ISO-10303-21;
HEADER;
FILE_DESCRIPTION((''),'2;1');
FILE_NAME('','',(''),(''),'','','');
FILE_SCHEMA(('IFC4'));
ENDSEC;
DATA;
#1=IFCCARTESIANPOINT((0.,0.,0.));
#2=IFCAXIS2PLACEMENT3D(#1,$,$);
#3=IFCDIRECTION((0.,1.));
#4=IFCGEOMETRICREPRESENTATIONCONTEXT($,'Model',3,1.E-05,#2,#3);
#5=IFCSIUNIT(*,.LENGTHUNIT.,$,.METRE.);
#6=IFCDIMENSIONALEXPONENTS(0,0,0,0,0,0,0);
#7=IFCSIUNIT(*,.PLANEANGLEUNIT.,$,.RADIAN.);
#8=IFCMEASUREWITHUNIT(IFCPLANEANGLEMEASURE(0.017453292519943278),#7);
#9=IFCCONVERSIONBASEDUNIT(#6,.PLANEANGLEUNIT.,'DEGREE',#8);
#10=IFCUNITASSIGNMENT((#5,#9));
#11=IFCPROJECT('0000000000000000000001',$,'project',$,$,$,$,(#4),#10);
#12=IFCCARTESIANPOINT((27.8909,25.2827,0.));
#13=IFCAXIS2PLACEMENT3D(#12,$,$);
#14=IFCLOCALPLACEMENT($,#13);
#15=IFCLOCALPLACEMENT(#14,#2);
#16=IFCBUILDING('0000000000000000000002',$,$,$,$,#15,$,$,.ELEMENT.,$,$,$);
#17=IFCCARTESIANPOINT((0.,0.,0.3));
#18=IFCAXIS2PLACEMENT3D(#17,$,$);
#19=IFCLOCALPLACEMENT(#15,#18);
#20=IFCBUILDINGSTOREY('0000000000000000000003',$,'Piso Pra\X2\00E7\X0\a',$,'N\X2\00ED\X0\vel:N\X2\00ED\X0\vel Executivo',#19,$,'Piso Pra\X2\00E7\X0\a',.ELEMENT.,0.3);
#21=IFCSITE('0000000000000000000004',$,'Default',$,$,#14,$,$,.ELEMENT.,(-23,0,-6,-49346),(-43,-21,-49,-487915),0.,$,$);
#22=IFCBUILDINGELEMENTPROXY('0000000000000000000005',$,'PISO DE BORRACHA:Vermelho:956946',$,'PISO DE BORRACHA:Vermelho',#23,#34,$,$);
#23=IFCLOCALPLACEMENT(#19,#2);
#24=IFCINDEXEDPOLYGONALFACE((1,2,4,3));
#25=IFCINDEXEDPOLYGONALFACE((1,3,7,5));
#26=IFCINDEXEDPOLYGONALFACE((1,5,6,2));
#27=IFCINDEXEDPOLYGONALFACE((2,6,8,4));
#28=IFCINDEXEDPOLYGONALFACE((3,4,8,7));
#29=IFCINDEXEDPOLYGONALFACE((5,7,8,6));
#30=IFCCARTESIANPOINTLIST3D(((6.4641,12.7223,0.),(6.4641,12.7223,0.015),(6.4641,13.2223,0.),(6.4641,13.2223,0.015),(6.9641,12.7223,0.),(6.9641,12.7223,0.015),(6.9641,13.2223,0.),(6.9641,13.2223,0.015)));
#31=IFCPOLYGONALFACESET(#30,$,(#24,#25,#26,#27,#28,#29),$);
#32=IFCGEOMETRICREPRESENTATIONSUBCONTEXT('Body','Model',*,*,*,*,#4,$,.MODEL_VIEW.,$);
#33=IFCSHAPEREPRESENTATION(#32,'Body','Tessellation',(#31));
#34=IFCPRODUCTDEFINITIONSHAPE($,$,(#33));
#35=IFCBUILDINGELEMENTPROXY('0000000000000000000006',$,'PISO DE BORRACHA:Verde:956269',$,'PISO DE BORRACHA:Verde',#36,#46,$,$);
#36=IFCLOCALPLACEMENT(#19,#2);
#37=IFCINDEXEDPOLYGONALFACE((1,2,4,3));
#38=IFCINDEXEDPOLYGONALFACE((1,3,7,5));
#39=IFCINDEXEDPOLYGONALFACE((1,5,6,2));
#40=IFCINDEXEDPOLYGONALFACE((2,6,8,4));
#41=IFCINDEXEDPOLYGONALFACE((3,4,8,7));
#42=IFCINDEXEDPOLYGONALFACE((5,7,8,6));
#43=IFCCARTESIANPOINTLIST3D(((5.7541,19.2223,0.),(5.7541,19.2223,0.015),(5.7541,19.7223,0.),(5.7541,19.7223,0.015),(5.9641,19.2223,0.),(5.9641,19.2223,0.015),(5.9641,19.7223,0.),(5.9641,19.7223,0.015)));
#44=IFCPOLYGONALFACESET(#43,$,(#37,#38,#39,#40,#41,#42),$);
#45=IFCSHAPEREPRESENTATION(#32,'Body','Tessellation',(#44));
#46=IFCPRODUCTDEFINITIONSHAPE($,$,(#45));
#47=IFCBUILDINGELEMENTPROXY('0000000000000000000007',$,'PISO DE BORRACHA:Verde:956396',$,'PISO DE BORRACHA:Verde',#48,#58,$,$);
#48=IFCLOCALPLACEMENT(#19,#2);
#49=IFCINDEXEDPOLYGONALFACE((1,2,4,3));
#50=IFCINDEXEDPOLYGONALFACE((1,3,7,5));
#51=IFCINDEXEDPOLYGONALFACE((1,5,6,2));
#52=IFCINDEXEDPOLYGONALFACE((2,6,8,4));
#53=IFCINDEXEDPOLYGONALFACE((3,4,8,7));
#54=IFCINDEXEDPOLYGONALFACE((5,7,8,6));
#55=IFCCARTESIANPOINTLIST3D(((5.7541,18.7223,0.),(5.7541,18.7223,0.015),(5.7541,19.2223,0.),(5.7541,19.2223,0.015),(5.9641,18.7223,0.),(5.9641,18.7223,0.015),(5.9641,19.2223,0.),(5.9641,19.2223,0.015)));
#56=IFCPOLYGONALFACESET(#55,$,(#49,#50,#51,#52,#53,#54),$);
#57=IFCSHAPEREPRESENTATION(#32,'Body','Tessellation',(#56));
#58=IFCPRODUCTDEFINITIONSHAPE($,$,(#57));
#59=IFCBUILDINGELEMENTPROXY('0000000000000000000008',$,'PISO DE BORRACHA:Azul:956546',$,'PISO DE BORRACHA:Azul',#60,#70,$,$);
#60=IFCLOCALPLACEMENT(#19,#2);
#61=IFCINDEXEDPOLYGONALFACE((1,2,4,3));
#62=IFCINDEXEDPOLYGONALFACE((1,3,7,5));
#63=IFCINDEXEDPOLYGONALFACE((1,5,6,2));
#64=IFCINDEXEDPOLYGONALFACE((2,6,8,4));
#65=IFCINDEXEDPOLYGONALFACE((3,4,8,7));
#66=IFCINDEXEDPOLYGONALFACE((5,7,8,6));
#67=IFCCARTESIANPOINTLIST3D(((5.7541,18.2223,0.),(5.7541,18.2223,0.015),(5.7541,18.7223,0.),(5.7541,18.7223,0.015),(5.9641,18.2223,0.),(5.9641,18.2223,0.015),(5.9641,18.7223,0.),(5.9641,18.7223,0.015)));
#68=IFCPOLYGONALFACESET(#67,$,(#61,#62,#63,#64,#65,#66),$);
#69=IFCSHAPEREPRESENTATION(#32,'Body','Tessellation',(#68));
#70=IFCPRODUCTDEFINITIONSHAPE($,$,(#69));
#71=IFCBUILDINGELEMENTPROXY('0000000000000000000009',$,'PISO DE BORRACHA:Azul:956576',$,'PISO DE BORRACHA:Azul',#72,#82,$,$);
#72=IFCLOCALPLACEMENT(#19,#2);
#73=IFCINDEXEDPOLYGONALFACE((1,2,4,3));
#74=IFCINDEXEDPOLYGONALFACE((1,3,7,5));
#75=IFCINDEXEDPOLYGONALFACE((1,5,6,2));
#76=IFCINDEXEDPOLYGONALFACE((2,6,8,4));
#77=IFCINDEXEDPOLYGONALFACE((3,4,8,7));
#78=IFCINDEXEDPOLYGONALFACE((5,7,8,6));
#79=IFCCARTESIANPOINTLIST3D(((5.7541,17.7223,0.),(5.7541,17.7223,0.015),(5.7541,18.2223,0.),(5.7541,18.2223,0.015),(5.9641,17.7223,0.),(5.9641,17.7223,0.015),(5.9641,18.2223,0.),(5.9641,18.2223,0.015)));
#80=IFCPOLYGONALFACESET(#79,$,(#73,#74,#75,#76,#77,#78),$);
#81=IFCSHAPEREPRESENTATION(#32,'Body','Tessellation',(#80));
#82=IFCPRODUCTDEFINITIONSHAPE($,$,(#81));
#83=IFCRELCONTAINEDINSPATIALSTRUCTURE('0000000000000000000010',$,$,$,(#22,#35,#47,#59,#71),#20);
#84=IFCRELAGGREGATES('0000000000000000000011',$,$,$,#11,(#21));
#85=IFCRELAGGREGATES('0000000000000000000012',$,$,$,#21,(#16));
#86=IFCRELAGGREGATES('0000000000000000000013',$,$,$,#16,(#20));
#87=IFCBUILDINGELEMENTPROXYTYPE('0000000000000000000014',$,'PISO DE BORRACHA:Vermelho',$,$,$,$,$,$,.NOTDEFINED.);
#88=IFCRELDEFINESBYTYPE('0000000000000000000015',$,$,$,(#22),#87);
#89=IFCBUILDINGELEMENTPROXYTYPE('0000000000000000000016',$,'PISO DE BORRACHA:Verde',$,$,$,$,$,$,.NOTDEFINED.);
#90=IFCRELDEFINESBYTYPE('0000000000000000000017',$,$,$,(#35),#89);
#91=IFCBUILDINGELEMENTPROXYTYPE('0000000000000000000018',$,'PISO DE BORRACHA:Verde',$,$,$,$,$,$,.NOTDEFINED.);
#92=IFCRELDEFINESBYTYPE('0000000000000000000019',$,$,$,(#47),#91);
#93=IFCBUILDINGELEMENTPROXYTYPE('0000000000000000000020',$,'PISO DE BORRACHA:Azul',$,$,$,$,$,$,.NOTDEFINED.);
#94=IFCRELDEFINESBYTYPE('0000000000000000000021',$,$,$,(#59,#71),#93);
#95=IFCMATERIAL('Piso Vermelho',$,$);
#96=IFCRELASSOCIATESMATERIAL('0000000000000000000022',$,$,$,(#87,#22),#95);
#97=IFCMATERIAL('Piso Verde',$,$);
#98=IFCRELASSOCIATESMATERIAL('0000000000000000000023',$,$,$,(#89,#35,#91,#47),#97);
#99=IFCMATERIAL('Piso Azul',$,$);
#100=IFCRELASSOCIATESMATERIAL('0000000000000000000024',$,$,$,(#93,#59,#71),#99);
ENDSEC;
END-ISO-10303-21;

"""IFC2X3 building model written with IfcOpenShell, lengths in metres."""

from ifc_helpers import new_model, entity, si_unit, converted_unit, direction, frame, frame_2d, origin, origin_2d_with_axis, place, context, subcontext, project, spatial, rectangle, extrude, source, transform, mapped, material, type_object, type_shapes, element, save


model = new_model("IFC2X3")

# Units and contexts
model_context = context("Model", 3, precision=1e-05, world=origin(), true_north=direction((0.0, 1.0)))
body_context = subcontext(model_context, "Body", "Model", "MODEL_VIEW")
ifc_project = project(units=[si_unit("LENGTHUNIT", "METRE"), converted_unit("PLANEANGLEUNIT", "DEGREE", entity("IfcPlaneAngleMeasure", 0.017453292519943278), si_unit("PLANEANGLEUNIT", "RADIAN"), dimensions=[0, 0, 0, 0, 0, 0, 0])], contexts=[model_context])

# Site, building, storey
site_placement = place(None, frame((27.8909, 25.2827, 0.0)))
site = spatial("IfcSite", under=ifc_project, at=site_placement, Name="Default", CompositionType="ELEMENT", RefLatitude=(-23, 0, -6, -49346), RefLongitude=(-43, -21, -49, -487915), RefElevation=0.0)
building_placement = place(site_placement, origin())
building = spatial("IfcBuilding", under=site, at=building_placement, CompositionType="ELEMENT")
storey_placement = place(building_placement, frame((0.0, 0.0, 0.3)))
storey = spatial("IfcBuildingStorey", under=building, at=storey_placement, Name="Piso Praça", ObjectType="Nível:Nível Executivo", LongName="Piso Praça", CompositionType="ELEMENT", Elevation=0.3)

# Building element proxies
ifc_material_1 = material(Name="Piso Verde")
ifc_material_2 = material(Name="Piso Azul")
ifc_material_3 = material(Name="Piso Vermelho")
building_element_proxy_type_1 = type_object("IfcBuildingElementProxyType", Name="PISO DE BORRACHA:Vermelho", PredefinedType="NOTDEFINED", material=ifc_material_3)
shared_shape_1 = source(origin(), body_context, "Body", "SweptSolid", [
    extrude(rectangle(XDim=0.5, YDim=0.5, at=origin_2d_with_axis()), frame((0.25, 0.25, 0.0), z_axis=(0.0, 0.0, 1.0), x_axis=(-1.0, 0.0, 0.0)), (0.0, 0.0, 1.0), 0.015),
])
type_shapes(building_element_proxy_type_1, [shared_shape_1])
for number, where, name in (
    (1, (6.4641, 12.7223, 0.0), "PISO DE BORRACHA:Vermelho:956946"),
):
    element("IfcBuildingElementProxy", number, at=place(storey_placement, frame(where)), inside=storey, type_object=building_element_proxy_type_1, material=ifc_material_3, Name=name, ObjectType="PISO DE BORRACHA:Vermelho", context=body_context, shape_type="MappedRepresentation", body=[
        mapped(shared_shape_1, transform((0.0, 0.0, 0.0), scale=1.0)),
    ])
building_element_proxy_type_2 = type_object("IfcBuildingElementProxyType", Name="PISO DE BORRACHA:Verde", PredefinedType="NOTDEFINED", material=ifc_material_1)
shared_shape_2 = source(origin(), body_context, "Body", "SweptSolid", [
    extrude(rectangle(XDim=0.21, YDim=0.5, at=frame_2d((0.0, 0.0), x_axis=(1.0, 0.0))), frame((0.105, 0.25, 0.0), z_axis=(0.0, 0.0, 1.0), x_axis=(-1.0, 0.0, 0.0)), (0.0, 0.0, 1.0), 0.015),
])
type_shapes(building_element_proxy_type_2, [shared_shape_2])
proxy_1_placement = place(storey_placement, frame((5.7541, 19.2223, 0.0)))
element("IfcBuildingElementProxy", 2, at=proxy_1_placement, inside=storey, type_object=building_element_proxy_type_2, material=ifc_material_1, Name="PISO DE BORRACHA:Verde:956269", ObjectType="PISO DE BORRACHA:Verde", context=body_context, shape_type="MappedRepresentation", body=[
    mapped(shared_shape_2, transform((0.0, 0.0, 0.0), scale=1.0)),
])
building_element_proxy_type_3 = type_object("IfcBuildingElementProxyType", Name="PISO DE BORRACHA:Verde", PredefinedType="NOTDEFINED", material=ifc_material_1)
shared_shape_3 = source(origin(), body_context, "Body", "SweptSolid", [
    extrude(rectangle(XDim=0.21, YDim=0.5, at=frame_2d((0.0, 0.0), x_axis=(1.0, 0.0))), frame((0.105, 0.25, 0.0), z_axis=(0.0, 0.0, 1.0), x_axis=(-1.0, 0.0, 0.0)), (0.0, 0.0, 1.0), 0.015),
])
type_shapes(building_element_proxy_type_3, [shared_shape_3])
proxy_2_placement = place(storey_placement, frame((5.7541, 18.7223, 0.0)))
element("IfcBuildingElementProxy", 3, at=proxy_2_placement, inside=storey, type_object=building_element_proxy_type_3, material=ifc_material_1, Name="PISO DE BORRACHA:Verde:956396", ObjectType="PISO DE BORRACHA:Verde", context=body_context, shape_type="MappedRepresentation", body=[
    mapped(shared_shape_3, transform((0.0, 0.0, 0.0), scale=1.0)),
])
building_element_proxy_type_4 = type_object("IfcBuildingElementProxyType", Name="PISO DE BORRACHA:Azul", PredefinedType="NOTDEFINED", material=ifc_material_2)
shared_shape_4 = source(origin(), body_context, "Body", "SweptSolid", [
    extrude(rectangle(XDim=0.21, YDim=0.5, at=frame_2d((0.0, 0.0), x_axis=(1.0, 0.0))), frame((0.105, 0.25, 0.0), z_axis=(0.0, 0.0, 1.0), x_axis=(-1.0, 0.0, 0.0)), (0.0, 0.0, 1.0), 0.015),
])
type_shapes(building_element_proxy_type_4, [shared_shape_4])
for number, where, name in (
    (4, (5.7541, 18.2223, 0.0), "PISO DE BORRACHA:Azul:956546"),
    (5, (5.7541, 17.7223, 0.0), "PISO DE BORRACHA:Azul:956576"),
):
    element("IfcBuildingElementProxy", number, at=place(storey_placement, frame(where)), inside=storey, type_object=building_element_proxy_type_4, material=ifc_material_2, Name=name, ObjectType="PISO DE BORRACHA:Azul", context=body_context, shape_type="MappedRepresentation", body=[
        mapped(shared_shape_4, transform((0.0, 0.0, 0.0), scale=1.0)),
    ])

save(model, "model.ifc")
